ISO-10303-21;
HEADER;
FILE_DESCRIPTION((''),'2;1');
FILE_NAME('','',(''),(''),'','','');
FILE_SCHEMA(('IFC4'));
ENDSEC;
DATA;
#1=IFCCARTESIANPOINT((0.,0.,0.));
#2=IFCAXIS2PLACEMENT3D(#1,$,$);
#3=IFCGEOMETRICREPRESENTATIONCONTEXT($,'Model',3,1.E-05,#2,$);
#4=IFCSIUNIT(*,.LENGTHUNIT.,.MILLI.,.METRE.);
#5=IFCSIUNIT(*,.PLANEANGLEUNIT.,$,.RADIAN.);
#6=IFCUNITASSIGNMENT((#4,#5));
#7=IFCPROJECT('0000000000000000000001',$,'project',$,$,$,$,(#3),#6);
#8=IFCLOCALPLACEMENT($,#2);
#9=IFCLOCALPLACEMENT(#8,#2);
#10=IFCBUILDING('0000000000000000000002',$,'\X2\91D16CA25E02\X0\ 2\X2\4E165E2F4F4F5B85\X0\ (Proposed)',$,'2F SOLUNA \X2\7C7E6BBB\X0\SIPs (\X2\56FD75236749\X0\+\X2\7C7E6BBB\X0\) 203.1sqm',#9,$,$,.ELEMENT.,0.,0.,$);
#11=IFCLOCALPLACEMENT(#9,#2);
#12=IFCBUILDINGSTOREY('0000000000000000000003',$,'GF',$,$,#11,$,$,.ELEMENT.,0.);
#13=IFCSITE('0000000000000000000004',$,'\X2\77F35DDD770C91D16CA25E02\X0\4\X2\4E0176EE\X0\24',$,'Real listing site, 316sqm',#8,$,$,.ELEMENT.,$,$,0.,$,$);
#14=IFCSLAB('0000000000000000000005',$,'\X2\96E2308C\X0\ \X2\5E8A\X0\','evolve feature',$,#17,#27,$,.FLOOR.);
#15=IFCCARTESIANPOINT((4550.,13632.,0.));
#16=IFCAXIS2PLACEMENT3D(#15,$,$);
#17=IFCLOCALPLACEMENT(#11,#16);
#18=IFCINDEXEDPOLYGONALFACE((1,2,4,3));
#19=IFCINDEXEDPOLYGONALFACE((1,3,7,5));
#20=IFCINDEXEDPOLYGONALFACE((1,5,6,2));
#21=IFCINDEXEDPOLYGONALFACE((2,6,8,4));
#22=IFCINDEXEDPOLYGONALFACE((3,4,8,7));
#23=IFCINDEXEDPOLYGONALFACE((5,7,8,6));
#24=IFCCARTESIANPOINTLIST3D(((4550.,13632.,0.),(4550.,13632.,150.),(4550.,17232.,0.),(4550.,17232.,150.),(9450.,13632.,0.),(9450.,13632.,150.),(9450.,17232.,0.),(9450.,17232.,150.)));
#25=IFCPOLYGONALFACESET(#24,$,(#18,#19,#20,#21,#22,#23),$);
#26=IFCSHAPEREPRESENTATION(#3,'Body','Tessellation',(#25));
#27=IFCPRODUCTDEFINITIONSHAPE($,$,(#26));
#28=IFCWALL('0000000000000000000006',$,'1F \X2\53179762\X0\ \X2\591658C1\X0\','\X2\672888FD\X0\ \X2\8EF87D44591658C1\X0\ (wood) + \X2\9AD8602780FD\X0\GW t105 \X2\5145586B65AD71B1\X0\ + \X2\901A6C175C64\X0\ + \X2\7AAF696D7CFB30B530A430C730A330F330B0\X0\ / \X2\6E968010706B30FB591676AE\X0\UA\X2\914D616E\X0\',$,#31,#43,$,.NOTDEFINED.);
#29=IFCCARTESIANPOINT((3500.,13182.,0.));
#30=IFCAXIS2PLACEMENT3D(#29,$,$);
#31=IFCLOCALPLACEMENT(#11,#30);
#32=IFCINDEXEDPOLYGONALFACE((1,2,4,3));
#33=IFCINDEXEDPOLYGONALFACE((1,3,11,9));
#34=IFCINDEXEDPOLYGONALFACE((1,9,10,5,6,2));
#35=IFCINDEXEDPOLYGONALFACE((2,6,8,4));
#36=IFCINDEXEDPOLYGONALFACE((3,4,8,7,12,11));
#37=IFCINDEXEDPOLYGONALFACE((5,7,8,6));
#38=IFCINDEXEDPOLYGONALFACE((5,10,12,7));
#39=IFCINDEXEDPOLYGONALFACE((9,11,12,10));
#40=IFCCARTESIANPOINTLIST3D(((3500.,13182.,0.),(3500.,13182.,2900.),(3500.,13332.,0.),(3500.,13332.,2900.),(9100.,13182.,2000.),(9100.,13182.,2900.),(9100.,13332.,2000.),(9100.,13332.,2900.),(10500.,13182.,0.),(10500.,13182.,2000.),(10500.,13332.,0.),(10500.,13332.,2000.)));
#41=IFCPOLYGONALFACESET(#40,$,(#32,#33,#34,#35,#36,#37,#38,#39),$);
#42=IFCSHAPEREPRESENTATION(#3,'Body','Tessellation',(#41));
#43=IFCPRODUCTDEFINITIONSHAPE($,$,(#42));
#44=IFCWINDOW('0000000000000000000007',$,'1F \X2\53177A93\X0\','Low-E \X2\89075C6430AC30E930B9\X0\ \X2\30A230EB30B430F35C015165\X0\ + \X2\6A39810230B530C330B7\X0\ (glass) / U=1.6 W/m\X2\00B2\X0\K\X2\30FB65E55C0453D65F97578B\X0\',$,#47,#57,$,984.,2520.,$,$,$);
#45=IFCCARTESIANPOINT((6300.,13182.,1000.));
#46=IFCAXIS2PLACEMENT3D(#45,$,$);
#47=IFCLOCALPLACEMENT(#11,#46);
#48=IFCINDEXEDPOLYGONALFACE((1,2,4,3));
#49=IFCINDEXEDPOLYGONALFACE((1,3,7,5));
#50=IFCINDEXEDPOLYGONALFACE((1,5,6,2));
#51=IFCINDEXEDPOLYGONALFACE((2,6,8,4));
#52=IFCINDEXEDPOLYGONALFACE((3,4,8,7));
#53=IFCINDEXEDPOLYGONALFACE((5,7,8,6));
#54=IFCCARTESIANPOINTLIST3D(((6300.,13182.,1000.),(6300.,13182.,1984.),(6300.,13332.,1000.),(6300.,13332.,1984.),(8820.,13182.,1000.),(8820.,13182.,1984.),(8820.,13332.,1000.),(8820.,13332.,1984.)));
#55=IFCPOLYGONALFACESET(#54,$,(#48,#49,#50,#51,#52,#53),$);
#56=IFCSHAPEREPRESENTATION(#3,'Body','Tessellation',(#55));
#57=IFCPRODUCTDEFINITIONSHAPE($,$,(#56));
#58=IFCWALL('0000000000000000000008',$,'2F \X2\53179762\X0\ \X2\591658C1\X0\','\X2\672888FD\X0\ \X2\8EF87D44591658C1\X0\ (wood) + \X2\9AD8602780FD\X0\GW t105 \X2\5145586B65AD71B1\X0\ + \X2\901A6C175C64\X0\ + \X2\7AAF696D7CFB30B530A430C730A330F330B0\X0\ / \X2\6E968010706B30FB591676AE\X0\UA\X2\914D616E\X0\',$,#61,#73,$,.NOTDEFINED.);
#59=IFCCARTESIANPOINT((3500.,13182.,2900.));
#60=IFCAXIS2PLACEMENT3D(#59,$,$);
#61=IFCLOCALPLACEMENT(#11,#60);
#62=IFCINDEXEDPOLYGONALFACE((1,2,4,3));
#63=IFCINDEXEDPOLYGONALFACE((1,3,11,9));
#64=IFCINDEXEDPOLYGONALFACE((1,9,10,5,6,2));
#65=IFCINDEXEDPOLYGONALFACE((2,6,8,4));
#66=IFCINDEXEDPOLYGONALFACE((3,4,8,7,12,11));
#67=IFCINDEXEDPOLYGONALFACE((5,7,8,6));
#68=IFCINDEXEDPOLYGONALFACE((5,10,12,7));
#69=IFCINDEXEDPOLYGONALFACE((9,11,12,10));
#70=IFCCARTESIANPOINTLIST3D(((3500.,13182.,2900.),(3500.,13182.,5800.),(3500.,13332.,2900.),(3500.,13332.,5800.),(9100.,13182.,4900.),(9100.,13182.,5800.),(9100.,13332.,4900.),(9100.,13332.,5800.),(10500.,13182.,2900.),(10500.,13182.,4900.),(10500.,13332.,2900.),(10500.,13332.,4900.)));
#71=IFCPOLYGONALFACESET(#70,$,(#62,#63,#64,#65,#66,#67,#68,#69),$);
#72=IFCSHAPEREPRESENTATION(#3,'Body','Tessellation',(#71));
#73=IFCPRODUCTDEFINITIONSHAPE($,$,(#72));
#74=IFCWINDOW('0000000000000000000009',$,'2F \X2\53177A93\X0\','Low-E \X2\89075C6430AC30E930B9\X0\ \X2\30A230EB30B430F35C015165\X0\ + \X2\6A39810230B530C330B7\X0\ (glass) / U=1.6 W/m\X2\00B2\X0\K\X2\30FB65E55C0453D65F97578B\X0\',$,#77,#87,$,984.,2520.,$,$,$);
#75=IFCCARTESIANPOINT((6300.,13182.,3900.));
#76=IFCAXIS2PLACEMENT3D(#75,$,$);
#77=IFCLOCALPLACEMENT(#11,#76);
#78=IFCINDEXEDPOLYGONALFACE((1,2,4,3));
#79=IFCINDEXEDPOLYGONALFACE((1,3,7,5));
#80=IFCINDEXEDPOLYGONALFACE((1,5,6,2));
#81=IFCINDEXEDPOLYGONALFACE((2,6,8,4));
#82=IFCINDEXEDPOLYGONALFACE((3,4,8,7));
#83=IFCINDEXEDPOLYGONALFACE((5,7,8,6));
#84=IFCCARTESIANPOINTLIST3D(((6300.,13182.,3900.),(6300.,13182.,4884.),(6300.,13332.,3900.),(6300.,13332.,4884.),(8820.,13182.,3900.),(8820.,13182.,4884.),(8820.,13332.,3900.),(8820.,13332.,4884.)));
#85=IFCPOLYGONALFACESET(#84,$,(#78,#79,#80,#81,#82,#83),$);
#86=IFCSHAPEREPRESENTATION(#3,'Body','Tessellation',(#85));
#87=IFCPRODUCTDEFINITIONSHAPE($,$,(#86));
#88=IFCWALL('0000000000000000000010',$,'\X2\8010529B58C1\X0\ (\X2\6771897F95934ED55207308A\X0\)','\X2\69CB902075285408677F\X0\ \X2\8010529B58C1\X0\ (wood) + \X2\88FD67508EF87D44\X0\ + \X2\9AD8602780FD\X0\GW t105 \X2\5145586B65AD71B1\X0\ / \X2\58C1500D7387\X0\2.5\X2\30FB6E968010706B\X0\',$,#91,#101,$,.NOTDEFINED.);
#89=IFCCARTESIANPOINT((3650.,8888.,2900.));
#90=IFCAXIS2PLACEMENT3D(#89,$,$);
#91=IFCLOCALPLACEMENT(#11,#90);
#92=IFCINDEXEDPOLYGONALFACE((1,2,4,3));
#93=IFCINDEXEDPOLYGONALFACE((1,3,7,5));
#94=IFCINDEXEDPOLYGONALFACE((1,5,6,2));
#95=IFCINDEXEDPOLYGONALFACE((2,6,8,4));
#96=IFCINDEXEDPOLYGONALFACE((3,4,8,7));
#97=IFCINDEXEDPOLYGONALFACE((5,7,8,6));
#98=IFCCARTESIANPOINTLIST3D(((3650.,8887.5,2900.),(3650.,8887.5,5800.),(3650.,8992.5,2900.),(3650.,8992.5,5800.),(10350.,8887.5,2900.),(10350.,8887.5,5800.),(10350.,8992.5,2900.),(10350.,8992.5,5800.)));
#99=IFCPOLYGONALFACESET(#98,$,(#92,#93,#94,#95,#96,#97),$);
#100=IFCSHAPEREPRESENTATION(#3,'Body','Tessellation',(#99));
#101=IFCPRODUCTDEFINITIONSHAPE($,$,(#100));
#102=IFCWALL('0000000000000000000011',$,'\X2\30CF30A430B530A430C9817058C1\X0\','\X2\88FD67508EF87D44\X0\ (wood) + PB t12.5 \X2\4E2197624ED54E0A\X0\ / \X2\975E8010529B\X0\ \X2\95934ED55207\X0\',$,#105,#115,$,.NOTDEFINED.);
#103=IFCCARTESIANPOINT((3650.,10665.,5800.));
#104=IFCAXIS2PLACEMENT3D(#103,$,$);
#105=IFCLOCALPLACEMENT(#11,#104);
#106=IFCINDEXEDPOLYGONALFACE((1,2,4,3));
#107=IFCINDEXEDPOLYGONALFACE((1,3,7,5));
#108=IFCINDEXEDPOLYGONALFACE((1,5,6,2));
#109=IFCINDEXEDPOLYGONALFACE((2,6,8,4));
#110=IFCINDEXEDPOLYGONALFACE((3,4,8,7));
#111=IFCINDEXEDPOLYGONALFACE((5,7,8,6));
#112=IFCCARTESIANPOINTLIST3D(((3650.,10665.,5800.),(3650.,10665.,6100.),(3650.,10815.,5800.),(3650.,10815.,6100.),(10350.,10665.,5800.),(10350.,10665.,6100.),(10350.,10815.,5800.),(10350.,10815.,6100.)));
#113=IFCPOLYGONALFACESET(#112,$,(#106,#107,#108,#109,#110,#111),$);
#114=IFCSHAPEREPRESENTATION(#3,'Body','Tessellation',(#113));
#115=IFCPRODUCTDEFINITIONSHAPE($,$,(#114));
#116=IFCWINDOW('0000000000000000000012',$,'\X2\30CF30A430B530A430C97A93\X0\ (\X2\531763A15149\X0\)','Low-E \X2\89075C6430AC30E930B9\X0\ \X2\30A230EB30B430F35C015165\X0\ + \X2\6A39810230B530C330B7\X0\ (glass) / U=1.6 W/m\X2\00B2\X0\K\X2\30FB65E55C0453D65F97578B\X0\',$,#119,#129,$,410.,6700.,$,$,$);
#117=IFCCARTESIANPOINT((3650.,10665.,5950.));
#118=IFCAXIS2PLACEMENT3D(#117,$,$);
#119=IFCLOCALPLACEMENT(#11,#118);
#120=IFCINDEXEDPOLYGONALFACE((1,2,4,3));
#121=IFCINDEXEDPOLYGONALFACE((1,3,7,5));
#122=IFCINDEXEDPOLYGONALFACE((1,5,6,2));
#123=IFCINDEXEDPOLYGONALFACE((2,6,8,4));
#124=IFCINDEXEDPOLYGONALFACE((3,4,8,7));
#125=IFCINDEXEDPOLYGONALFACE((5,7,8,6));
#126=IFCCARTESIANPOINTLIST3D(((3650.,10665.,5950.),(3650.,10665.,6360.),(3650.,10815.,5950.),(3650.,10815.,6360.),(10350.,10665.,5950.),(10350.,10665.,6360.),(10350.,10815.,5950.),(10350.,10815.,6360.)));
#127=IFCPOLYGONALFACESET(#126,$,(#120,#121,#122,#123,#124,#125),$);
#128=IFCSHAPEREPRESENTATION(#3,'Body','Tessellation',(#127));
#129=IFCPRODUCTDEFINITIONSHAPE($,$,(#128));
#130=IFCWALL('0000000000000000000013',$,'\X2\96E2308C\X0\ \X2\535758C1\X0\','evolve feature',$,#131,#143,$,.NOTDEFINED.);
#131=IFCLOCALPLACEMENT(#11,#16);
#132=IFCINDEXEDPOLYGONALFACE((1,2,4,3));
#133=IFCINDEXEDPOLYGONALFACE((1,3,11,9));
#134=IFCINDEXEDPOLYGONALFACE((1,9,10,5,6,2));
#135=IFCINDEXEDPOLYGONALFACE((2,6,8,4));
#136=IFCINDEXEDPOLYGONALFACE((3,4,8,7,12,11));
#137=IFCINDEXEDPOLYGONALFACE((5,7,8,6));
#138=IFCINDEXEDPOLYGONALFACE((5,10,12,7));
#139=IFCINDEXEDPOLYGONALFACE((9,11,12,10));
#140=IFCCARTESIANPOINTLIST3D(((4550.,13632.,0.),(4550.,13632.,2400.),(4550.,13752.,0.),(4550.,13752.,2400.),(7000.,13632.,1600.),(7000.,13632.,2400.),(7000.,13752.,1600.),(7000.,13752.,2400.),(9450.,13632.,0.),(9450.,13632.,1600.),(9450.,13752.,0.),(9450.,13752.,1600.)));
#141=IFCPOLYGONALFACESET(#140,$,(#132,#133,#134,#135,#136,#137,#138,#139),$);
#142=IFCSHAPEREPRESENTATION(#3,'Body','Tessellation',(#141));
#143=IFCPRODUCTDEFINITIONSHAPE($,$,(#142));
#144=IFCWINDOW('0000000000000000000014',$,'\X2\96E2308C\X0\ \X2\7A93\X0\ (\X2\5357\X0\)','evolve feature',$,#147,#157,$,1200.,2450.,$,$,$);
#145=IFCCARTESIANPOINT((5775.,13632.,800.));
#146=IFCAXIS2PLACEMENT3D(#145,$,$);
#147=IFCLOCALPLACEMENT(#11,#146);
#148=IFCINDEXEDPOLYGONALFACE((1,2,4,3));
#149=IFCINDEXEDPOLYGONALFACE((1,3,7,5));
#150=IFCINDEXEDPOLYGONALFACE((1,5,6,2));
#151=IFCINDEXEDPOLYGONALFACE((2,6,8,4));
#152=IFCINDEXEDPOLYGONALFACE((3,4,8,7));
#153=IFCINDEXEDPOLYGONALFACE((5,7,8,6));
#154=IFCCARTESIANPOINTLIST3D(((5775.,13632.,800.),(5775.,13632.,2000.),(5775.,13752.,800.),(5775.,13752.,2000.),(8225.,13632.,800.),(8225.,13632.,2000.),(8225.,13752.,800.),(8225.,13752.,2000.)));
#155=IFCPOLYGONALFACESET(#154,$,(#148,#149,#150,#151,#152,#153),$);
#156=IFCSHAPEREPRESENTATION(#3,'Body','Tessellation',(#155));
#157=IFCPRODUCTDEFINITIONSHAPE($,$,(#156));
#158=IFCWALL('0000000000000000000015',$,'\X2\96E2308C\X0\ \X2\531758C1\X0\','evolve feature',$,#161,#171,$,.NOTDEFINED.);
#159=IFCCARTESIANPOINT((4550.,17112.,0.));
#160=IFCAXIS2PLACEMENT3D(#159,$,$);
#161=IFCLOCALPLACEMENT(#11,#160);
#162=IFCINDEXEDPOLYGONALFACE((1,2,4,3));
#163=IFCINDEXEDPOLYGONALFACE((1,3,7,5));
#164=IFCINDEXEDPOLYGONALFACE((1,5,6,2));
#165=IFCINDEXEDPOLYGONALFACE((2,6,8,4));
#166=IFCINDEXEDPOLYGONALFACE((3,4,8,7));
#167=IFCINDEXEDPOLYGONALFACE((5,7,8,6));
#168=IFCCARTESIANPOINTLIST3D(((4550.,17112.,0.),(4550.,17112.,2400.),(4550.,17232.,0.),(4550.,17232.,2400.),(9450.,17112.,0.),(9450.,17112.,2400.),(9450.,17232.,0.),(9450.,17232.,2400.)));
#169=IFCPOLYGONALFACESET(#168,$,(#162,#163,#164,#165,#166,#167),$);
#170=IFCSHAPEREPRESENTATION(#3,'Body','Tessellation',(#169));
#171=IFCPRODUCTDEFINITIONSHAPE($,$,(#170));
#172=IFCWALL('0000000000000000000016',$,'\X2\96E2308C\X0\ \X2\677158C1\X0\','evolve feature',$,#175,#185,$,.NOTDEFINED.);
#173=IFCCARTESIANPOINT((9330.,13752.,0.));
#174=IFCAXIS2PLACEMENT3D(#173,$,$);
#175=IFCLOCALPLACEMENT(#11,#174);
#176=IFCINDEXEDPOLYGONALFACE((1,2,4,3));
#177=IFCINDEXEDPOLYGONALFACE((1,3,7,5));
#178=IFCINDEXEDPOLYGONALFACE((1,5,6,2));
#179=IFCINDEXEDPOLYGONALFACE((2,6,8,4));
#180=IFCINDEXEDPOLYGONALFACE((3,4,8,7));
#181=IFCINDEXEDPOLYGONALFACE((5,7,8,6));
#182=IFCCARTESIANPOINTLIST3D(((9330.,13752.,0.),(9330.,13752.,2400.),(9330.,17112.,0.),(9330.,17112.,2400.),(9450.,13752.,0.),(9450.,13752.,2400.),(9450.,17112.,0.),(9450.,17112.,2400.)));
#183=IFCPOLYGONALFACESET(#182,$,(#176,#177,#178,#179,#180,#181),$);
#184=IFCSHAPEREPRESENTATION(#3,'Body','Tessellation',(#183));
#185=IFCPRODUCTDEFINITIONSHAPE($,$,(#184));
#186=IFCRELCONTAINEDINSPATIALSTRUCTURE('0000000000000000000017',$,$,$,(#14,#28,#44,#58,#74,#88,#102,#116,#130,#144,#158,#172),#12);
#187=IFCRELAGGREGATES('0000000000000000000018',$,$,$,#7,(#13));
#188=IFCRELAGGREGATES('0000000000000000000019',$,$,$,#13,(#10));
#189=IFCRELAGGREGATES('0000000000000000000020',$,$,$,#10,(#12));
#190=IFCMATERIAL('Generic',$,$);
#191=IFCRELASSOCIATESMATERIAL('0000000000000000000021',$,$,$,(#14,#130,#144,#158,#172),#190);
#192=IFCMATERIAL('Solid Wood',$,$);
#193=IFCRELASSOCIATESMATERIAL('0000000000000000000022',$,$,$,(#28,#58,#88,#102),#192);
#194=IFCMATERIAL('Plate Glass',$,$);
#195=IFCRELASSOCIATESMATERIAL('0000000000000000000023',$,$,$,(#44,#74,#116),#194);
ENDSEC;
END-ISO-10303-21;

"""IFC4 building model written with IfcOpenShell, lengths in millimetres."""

from ifc_helpers import new_model, si_unit, frame, frame_2d, origin, place, context, project, spatial, rectangle, extrude, material, element, fill, save


model = new_model("IFC4")

# Units and contexts
model_context = context("Model", 3, precision=1e-05, world=origin())
ifc_project = project(units=[si_unit("LENGTHUNIT", "METRE", prefix="MILLI"), si_unit("PLANEANGLEUNIT", "RADIAN")], contexts=[model_context])

# Site, building, storey
site_placement = place(None, origin())
site = spatial("IfcSite", under=ifc_project, at=site_placement, Name="石川県金沢市4丁目24", ObjectType="Real listing site, 316sqm", CompositionType="ELEMENT", RefElevation=0.0)
building_placement = place(site_placement, origin())
building = spatial("IfcBuilding", under=site, at=building_placement, Name="金沢市 2世帯住宅 (Proposed)", ObjectType="2F SOLUNA 籾殻SIPs (国産杉+籾殻) 203.1sqm", CompositionType="ELEMENT", ElevationOfRefHeight=0.0, ElevationOfTerrain=0.0)
storey_placement = place(building_placement, origin())
storey = spatial("IfcBuildingStorey", under=building, at=storey_placement, Name="GF", CompositionType="ELEMENT", Elevation=0.0)

# Slab
ifc_material_1 = material(Name="Generic")
slab_placement = place(storey_placement, frame((4550.0, 13632.0, 0.0)))
element("IfcSlab", 1, at=slab_placement, inside=storey, material=ifc_material_1, Name="離れ 床", Description="evolve feature", PredefinedType="FLOOR", context=model_context, shape_type="SweptSolid", body=[
    extrude(rectangle(XDim=4900.0, YDim=3600.0, at=frame_2d((2450.0, 1800.0))), frame((4550.0, 13632.0, 0.0)), (0.0, 0.0, 1.0), 150.0),
])

# Wall, opening, window
ifc_material_2 = material(Name="Solid Wood")
wall_1_placement = place(storey_placement, frame((3500.0, 13182.0, 0.0)))
wall_1 = element("IfcWall", 2, at=wall_1_placement, inside=storey, material=ifc_material_2, Name="1F 北面 外壁", Description="木製 軸組外壁 (wood) + 高性能GW t105 充填断熱 + 通気層 + 窯業系サイディング / 準耐火・外皮UA配慮", PredefinedType="NOTDEFINED", context=model_context, shape_type="SweptSolid", body=[
    extrude(rectangle(XDim=7000.0, YDim=150.0, at=frame_2d((3500.0, 75.0))), frame((3500.0, 13182.0, 0.0)), (0.0, 0.0, 1.0), 2900.0),
])
opening_1_placement = place(storey_placement, frame((6300.0, 13182.0, 1000.0)))
opening_1 = element("IfcOpeningElement", 3, at=opening_1_placement, cuts=wall_1, PredefinedType="NOTDEFINED", context=model_context, shape_type="SweptSolid", body=[
    extrude(rectangle(XDim=2520.0, YDim=150.0, at=frame_2d((1260.0, 75.0))), frame((6300.0, 13182.0, 1000.0)), (0.0, 0.0, 1.0), 984.0),
])
ifc_material_3 = material(Name="Plate Glass")
window_1_placement = place(storey_placement, frame((6300.0, 13182.0, 1000.0)))
window_1 = element("IfcWindow", 4, at=window_1_placement, inside=storey, material=ifc_material_3, Name="1F 北窓", Description="Low-E 複層ガラス アルゴン封入 + 樹脂サッシ (glass) / U=1.6 W/m²K・日射取得型", OverallHeight=984.0, OverallWidth=2520.0, context=model_context, shape_type="SweptSolid", body=[
    extrude(rectangle(XDim=2520.0, YDim=150.0, at=frame_2d((1260.0, 75.0))), frame((6300.0, 13182.0, 1000.0)), (0.0, 0.0, 1.0), 984.0),
])
fill(opening_1, window_1)

# Wall, opening, window
wall_2_placement = place(storey_placement, frame((3500.0, 13182.0, 2900.0)))
wall_2 = element("IfcWall", 5, at=wall_2_placement, inside=storey, material=ifc_material_2, Name="2F 北面 外壁", Description="木製 軸組外壁 (wood) + 高性能GW t105 充填断熱 + 通気層 + 窯業系サイディング / 準耐火・外皮UA配慮", PredefinedType="NOTDEFINED", context=model_context, shape_type="SweptSolid", body=[
    extrude(rectangle(XDim=7000.0, YDim=150.0, at=frame_2d((3500.0, 75.0))), frame((3500.0, 13182.0, 2900.0)), (0.0, 0.0, 1.0), 2900.0),
])
opening_2_placement = place(storey_placement, frame((6300.0, 13182.0, 3900.0)))
opening_2 = element("IfcOpeningElement", 6, at=opening_2_placement, cuts=wall_2, PredefinedType="NOTDEFINED", context=model_context, shape_type="SweptSolid", body=[
    extrude(rectangle(XDim=2520.0, YDim=150.0, at=frame_2d((1260.0, 75.0))), frame((6300.0, 13182.0, 3900.0)), (0.0, 0.0, 1.0), 984.0),
])
window_2_placement = place(storey_placement, frame((6300.0, 13182.0, 3900.0)))
window_2 = element("IfcWindow", 7, at=window_2_placement, inside=storey, material=ifc_material_3, Name="2F 北窓", Description="Low-E 複層ガラス アルゴン封入 + 樹脂サッシ (glass) / U=1.6 W/m²K・日射取得型", OverallHeight=984.0, OverallWidth=2520.0, context=model_context, shape_type="SweptSolid", body=[
    extrude(rectangle(XDim=2520.0, YDim=150.0, at=frame_2d((1260.0, 75.0))), frame((6300.0, 13182.0, 3900.0)), (0.0, 0.0, 1.0), 984.0),
])
fill(opening_2, window_2)

# Wall
wall_3_placement = place(storey_placement, frame((3650.0, 8888.0, 2900.0)))
element("IfcWall", 8, at=wall_3_placement, inside=storey, material=ifc_material_2, Name="耐力壁 (東西間仕切り)", Description="構造用合板 耐力壁 (wood) + 製材軸組 + 高性能GW t105 充填断熱 / 壁倍率2.5・準耐火", PredefinedType="NOTDEFINED", context=model_context, shape_type="SweptSolid", body=[
    extrude(rectangle(XDim=6700.0, YDim=105.0, at=frame_2d((3350.0, 52.0))), frame((3650.0, 8888.0, 2900.0)), (0.0, 0.0, 1.0), 2900.0),
])

# Walls, openings, windows
wall_4_placement = place(storey_placement, frame((3650.0, 10665.0, 5800.0)))
wall_4 = element("IfcWall", 9, at=wall_4_placement, inside=storey, material=ifc_material_2, Name="ハイサイド腰壁", Description="製材軸組 (wood) + PB t12.5 両面仕上 / 非耐力 間仕切", PredefinedType="NOTDEFINED", context=model_context, shape_type="SweptSolid", body=[
    extrude(rectangle(XDim=6700.0, YDim=150.0, at=frame_2d((3350.0, 75.0))), frame((3650.0, 10665.0, 5800.0)), (0.0, 0.0, 1.0), 700.0),
])
opening_3_placement = place(storey_placement, frame((3650.0, 10665.0, 5950.0)))
opening_3 = element("IfcOpeningElement", 10, at=opening_3_placement, cuts=wall_4, PredefinedType="NOTDEFINED", context=model_context, shape_type="SweptSolid", body=[
    extrude(rectangle(XDim=6700.0, YDim=150.0, at=frame_2d((3350.0, 75.0))), frame((3650.0, 10665.0, 5950.0)), (0.0, 0.0, 1.0), 410.0),
])
window_3_placement = place(storey_placement, frame((3650.0, 10665.0, 5950.0)))
window_3 = element("IfcWindow", 11, at=window_3_placement, inside=storey, material=ifc_material_3, Name="ハイサイド窓 (北採光)", Description="Low-E 複層ガラス アルゴン封入 + 樹脂サッシ (glass) / U=1.6 W/m²K・日射取得型", OverallHeight=410.0, OverallWidth=6700.0, context=model_context, shape_type="SweptSolid", body=[
    extrude(rectangle(XDim=6700.0, YDim=150.0, at=frame_2d((3350.0, 75.0))), frame((3650.0, 10665.0, 5950.0)), (0.0, 0.0, 1.0), 410.0),
])
fill(opening_3, window_3)
wall_5_placement = place(storey_placement, frame((4550.0, 13632.0, 0.0)))
wall_5 = element("IfcWall", 12, at=wall_5_placement, inside=storey, material=ifc_material_1, Name="離れ 南壁", Description="evolve feature", PredefinedType="NOTDEFINED", context=model_context, shape_type="SweptSolid", body=[
    extrude(rectangle(XDim=4900.0, YDim=120.0, at=frame_2d((2450.0, 60.0))), frame((4550.0, 13632.0, 0.0)), (0.0, 0.0, 1.0), 2400.0),
])
opening_4_placement = place(storey_placement, frame((5775.0, 13632.0, 800.0)))
opening_4 = element("IfcOpeningElement", 13, at=opening_4_placement, cuts=wall_5, PredefinedType="NOTDEFINED", context=model_context, shape_type="SweptSolid", body=[
    extrude(rectangle(XDim=2450.0, YDim=120.0, at=frame_2d((1225.0, 60.0))), frame((5775.0, 13632.0, 800.0)), (0.0, 0.0, 1.0), 1200.0),
])
window_4_placement = place(storey_placement, frame((5775.0, 13632.0, 800.0)))
window_4 = element("IfcWindow", 14, at=window_4_placement, inside=storey, material=ifc_material_1, Name="離れ 窓 (南)", Description="evolve feature", OverallHeight=1200.0, OverallWidth=2450.0, context=model_context, shape_type="SweptSolid", body=[
    extrude(rectangle(XDim=2450.0, YDim=120.0, at=frame_2d((1225.0, 60.0))), frame((5775.0, 13632.0, 800.0)), (0.0, 0.0, 1.0), 1200.0),
])
fill(opening_4, window_4)

# Walls
wall_6_placement = place(storey_placement, frame((4550.0, 17112.0, 0.0)))
element("IfcWall", 15, at=wall_6_placement, inside=storey, material=ifc_material_1, Name="離れ 北壁", Description="evolve feature", PredefinedType="NOTDEFINED", context=model_context, shape_type="SweptSolid", body=[
    extrude(rectangle(XDim=4900.0, YDim=120.0, at=frame_2d((2450.0, 60.0))), frame((4550.0, 17112.0, 0.0)), (0.0, 0.0, 1.0), 2400.0),
])
wall_7_placement = place(storey_placement, frame((9330.0, 13752.0, 0.0)))
element("IfcWall", 16, at=wall_7_placement, inside=storey, material=ifc_material_1, Name="離れ 東壁", Description="evolve feature", PredefinedType="NOTDEFINED", context=model_context, shape_type="SweptSolid", body=[
    extrude(rectangle(XDim=120.0, YDim=3360.0, at=frame_2d((60.0, 1680.0))), frame((9330.0, 13752.0, 0.0)), (0.0, 0.0, 1.0), 2400.0),
])

save(model, "model.ifc")
